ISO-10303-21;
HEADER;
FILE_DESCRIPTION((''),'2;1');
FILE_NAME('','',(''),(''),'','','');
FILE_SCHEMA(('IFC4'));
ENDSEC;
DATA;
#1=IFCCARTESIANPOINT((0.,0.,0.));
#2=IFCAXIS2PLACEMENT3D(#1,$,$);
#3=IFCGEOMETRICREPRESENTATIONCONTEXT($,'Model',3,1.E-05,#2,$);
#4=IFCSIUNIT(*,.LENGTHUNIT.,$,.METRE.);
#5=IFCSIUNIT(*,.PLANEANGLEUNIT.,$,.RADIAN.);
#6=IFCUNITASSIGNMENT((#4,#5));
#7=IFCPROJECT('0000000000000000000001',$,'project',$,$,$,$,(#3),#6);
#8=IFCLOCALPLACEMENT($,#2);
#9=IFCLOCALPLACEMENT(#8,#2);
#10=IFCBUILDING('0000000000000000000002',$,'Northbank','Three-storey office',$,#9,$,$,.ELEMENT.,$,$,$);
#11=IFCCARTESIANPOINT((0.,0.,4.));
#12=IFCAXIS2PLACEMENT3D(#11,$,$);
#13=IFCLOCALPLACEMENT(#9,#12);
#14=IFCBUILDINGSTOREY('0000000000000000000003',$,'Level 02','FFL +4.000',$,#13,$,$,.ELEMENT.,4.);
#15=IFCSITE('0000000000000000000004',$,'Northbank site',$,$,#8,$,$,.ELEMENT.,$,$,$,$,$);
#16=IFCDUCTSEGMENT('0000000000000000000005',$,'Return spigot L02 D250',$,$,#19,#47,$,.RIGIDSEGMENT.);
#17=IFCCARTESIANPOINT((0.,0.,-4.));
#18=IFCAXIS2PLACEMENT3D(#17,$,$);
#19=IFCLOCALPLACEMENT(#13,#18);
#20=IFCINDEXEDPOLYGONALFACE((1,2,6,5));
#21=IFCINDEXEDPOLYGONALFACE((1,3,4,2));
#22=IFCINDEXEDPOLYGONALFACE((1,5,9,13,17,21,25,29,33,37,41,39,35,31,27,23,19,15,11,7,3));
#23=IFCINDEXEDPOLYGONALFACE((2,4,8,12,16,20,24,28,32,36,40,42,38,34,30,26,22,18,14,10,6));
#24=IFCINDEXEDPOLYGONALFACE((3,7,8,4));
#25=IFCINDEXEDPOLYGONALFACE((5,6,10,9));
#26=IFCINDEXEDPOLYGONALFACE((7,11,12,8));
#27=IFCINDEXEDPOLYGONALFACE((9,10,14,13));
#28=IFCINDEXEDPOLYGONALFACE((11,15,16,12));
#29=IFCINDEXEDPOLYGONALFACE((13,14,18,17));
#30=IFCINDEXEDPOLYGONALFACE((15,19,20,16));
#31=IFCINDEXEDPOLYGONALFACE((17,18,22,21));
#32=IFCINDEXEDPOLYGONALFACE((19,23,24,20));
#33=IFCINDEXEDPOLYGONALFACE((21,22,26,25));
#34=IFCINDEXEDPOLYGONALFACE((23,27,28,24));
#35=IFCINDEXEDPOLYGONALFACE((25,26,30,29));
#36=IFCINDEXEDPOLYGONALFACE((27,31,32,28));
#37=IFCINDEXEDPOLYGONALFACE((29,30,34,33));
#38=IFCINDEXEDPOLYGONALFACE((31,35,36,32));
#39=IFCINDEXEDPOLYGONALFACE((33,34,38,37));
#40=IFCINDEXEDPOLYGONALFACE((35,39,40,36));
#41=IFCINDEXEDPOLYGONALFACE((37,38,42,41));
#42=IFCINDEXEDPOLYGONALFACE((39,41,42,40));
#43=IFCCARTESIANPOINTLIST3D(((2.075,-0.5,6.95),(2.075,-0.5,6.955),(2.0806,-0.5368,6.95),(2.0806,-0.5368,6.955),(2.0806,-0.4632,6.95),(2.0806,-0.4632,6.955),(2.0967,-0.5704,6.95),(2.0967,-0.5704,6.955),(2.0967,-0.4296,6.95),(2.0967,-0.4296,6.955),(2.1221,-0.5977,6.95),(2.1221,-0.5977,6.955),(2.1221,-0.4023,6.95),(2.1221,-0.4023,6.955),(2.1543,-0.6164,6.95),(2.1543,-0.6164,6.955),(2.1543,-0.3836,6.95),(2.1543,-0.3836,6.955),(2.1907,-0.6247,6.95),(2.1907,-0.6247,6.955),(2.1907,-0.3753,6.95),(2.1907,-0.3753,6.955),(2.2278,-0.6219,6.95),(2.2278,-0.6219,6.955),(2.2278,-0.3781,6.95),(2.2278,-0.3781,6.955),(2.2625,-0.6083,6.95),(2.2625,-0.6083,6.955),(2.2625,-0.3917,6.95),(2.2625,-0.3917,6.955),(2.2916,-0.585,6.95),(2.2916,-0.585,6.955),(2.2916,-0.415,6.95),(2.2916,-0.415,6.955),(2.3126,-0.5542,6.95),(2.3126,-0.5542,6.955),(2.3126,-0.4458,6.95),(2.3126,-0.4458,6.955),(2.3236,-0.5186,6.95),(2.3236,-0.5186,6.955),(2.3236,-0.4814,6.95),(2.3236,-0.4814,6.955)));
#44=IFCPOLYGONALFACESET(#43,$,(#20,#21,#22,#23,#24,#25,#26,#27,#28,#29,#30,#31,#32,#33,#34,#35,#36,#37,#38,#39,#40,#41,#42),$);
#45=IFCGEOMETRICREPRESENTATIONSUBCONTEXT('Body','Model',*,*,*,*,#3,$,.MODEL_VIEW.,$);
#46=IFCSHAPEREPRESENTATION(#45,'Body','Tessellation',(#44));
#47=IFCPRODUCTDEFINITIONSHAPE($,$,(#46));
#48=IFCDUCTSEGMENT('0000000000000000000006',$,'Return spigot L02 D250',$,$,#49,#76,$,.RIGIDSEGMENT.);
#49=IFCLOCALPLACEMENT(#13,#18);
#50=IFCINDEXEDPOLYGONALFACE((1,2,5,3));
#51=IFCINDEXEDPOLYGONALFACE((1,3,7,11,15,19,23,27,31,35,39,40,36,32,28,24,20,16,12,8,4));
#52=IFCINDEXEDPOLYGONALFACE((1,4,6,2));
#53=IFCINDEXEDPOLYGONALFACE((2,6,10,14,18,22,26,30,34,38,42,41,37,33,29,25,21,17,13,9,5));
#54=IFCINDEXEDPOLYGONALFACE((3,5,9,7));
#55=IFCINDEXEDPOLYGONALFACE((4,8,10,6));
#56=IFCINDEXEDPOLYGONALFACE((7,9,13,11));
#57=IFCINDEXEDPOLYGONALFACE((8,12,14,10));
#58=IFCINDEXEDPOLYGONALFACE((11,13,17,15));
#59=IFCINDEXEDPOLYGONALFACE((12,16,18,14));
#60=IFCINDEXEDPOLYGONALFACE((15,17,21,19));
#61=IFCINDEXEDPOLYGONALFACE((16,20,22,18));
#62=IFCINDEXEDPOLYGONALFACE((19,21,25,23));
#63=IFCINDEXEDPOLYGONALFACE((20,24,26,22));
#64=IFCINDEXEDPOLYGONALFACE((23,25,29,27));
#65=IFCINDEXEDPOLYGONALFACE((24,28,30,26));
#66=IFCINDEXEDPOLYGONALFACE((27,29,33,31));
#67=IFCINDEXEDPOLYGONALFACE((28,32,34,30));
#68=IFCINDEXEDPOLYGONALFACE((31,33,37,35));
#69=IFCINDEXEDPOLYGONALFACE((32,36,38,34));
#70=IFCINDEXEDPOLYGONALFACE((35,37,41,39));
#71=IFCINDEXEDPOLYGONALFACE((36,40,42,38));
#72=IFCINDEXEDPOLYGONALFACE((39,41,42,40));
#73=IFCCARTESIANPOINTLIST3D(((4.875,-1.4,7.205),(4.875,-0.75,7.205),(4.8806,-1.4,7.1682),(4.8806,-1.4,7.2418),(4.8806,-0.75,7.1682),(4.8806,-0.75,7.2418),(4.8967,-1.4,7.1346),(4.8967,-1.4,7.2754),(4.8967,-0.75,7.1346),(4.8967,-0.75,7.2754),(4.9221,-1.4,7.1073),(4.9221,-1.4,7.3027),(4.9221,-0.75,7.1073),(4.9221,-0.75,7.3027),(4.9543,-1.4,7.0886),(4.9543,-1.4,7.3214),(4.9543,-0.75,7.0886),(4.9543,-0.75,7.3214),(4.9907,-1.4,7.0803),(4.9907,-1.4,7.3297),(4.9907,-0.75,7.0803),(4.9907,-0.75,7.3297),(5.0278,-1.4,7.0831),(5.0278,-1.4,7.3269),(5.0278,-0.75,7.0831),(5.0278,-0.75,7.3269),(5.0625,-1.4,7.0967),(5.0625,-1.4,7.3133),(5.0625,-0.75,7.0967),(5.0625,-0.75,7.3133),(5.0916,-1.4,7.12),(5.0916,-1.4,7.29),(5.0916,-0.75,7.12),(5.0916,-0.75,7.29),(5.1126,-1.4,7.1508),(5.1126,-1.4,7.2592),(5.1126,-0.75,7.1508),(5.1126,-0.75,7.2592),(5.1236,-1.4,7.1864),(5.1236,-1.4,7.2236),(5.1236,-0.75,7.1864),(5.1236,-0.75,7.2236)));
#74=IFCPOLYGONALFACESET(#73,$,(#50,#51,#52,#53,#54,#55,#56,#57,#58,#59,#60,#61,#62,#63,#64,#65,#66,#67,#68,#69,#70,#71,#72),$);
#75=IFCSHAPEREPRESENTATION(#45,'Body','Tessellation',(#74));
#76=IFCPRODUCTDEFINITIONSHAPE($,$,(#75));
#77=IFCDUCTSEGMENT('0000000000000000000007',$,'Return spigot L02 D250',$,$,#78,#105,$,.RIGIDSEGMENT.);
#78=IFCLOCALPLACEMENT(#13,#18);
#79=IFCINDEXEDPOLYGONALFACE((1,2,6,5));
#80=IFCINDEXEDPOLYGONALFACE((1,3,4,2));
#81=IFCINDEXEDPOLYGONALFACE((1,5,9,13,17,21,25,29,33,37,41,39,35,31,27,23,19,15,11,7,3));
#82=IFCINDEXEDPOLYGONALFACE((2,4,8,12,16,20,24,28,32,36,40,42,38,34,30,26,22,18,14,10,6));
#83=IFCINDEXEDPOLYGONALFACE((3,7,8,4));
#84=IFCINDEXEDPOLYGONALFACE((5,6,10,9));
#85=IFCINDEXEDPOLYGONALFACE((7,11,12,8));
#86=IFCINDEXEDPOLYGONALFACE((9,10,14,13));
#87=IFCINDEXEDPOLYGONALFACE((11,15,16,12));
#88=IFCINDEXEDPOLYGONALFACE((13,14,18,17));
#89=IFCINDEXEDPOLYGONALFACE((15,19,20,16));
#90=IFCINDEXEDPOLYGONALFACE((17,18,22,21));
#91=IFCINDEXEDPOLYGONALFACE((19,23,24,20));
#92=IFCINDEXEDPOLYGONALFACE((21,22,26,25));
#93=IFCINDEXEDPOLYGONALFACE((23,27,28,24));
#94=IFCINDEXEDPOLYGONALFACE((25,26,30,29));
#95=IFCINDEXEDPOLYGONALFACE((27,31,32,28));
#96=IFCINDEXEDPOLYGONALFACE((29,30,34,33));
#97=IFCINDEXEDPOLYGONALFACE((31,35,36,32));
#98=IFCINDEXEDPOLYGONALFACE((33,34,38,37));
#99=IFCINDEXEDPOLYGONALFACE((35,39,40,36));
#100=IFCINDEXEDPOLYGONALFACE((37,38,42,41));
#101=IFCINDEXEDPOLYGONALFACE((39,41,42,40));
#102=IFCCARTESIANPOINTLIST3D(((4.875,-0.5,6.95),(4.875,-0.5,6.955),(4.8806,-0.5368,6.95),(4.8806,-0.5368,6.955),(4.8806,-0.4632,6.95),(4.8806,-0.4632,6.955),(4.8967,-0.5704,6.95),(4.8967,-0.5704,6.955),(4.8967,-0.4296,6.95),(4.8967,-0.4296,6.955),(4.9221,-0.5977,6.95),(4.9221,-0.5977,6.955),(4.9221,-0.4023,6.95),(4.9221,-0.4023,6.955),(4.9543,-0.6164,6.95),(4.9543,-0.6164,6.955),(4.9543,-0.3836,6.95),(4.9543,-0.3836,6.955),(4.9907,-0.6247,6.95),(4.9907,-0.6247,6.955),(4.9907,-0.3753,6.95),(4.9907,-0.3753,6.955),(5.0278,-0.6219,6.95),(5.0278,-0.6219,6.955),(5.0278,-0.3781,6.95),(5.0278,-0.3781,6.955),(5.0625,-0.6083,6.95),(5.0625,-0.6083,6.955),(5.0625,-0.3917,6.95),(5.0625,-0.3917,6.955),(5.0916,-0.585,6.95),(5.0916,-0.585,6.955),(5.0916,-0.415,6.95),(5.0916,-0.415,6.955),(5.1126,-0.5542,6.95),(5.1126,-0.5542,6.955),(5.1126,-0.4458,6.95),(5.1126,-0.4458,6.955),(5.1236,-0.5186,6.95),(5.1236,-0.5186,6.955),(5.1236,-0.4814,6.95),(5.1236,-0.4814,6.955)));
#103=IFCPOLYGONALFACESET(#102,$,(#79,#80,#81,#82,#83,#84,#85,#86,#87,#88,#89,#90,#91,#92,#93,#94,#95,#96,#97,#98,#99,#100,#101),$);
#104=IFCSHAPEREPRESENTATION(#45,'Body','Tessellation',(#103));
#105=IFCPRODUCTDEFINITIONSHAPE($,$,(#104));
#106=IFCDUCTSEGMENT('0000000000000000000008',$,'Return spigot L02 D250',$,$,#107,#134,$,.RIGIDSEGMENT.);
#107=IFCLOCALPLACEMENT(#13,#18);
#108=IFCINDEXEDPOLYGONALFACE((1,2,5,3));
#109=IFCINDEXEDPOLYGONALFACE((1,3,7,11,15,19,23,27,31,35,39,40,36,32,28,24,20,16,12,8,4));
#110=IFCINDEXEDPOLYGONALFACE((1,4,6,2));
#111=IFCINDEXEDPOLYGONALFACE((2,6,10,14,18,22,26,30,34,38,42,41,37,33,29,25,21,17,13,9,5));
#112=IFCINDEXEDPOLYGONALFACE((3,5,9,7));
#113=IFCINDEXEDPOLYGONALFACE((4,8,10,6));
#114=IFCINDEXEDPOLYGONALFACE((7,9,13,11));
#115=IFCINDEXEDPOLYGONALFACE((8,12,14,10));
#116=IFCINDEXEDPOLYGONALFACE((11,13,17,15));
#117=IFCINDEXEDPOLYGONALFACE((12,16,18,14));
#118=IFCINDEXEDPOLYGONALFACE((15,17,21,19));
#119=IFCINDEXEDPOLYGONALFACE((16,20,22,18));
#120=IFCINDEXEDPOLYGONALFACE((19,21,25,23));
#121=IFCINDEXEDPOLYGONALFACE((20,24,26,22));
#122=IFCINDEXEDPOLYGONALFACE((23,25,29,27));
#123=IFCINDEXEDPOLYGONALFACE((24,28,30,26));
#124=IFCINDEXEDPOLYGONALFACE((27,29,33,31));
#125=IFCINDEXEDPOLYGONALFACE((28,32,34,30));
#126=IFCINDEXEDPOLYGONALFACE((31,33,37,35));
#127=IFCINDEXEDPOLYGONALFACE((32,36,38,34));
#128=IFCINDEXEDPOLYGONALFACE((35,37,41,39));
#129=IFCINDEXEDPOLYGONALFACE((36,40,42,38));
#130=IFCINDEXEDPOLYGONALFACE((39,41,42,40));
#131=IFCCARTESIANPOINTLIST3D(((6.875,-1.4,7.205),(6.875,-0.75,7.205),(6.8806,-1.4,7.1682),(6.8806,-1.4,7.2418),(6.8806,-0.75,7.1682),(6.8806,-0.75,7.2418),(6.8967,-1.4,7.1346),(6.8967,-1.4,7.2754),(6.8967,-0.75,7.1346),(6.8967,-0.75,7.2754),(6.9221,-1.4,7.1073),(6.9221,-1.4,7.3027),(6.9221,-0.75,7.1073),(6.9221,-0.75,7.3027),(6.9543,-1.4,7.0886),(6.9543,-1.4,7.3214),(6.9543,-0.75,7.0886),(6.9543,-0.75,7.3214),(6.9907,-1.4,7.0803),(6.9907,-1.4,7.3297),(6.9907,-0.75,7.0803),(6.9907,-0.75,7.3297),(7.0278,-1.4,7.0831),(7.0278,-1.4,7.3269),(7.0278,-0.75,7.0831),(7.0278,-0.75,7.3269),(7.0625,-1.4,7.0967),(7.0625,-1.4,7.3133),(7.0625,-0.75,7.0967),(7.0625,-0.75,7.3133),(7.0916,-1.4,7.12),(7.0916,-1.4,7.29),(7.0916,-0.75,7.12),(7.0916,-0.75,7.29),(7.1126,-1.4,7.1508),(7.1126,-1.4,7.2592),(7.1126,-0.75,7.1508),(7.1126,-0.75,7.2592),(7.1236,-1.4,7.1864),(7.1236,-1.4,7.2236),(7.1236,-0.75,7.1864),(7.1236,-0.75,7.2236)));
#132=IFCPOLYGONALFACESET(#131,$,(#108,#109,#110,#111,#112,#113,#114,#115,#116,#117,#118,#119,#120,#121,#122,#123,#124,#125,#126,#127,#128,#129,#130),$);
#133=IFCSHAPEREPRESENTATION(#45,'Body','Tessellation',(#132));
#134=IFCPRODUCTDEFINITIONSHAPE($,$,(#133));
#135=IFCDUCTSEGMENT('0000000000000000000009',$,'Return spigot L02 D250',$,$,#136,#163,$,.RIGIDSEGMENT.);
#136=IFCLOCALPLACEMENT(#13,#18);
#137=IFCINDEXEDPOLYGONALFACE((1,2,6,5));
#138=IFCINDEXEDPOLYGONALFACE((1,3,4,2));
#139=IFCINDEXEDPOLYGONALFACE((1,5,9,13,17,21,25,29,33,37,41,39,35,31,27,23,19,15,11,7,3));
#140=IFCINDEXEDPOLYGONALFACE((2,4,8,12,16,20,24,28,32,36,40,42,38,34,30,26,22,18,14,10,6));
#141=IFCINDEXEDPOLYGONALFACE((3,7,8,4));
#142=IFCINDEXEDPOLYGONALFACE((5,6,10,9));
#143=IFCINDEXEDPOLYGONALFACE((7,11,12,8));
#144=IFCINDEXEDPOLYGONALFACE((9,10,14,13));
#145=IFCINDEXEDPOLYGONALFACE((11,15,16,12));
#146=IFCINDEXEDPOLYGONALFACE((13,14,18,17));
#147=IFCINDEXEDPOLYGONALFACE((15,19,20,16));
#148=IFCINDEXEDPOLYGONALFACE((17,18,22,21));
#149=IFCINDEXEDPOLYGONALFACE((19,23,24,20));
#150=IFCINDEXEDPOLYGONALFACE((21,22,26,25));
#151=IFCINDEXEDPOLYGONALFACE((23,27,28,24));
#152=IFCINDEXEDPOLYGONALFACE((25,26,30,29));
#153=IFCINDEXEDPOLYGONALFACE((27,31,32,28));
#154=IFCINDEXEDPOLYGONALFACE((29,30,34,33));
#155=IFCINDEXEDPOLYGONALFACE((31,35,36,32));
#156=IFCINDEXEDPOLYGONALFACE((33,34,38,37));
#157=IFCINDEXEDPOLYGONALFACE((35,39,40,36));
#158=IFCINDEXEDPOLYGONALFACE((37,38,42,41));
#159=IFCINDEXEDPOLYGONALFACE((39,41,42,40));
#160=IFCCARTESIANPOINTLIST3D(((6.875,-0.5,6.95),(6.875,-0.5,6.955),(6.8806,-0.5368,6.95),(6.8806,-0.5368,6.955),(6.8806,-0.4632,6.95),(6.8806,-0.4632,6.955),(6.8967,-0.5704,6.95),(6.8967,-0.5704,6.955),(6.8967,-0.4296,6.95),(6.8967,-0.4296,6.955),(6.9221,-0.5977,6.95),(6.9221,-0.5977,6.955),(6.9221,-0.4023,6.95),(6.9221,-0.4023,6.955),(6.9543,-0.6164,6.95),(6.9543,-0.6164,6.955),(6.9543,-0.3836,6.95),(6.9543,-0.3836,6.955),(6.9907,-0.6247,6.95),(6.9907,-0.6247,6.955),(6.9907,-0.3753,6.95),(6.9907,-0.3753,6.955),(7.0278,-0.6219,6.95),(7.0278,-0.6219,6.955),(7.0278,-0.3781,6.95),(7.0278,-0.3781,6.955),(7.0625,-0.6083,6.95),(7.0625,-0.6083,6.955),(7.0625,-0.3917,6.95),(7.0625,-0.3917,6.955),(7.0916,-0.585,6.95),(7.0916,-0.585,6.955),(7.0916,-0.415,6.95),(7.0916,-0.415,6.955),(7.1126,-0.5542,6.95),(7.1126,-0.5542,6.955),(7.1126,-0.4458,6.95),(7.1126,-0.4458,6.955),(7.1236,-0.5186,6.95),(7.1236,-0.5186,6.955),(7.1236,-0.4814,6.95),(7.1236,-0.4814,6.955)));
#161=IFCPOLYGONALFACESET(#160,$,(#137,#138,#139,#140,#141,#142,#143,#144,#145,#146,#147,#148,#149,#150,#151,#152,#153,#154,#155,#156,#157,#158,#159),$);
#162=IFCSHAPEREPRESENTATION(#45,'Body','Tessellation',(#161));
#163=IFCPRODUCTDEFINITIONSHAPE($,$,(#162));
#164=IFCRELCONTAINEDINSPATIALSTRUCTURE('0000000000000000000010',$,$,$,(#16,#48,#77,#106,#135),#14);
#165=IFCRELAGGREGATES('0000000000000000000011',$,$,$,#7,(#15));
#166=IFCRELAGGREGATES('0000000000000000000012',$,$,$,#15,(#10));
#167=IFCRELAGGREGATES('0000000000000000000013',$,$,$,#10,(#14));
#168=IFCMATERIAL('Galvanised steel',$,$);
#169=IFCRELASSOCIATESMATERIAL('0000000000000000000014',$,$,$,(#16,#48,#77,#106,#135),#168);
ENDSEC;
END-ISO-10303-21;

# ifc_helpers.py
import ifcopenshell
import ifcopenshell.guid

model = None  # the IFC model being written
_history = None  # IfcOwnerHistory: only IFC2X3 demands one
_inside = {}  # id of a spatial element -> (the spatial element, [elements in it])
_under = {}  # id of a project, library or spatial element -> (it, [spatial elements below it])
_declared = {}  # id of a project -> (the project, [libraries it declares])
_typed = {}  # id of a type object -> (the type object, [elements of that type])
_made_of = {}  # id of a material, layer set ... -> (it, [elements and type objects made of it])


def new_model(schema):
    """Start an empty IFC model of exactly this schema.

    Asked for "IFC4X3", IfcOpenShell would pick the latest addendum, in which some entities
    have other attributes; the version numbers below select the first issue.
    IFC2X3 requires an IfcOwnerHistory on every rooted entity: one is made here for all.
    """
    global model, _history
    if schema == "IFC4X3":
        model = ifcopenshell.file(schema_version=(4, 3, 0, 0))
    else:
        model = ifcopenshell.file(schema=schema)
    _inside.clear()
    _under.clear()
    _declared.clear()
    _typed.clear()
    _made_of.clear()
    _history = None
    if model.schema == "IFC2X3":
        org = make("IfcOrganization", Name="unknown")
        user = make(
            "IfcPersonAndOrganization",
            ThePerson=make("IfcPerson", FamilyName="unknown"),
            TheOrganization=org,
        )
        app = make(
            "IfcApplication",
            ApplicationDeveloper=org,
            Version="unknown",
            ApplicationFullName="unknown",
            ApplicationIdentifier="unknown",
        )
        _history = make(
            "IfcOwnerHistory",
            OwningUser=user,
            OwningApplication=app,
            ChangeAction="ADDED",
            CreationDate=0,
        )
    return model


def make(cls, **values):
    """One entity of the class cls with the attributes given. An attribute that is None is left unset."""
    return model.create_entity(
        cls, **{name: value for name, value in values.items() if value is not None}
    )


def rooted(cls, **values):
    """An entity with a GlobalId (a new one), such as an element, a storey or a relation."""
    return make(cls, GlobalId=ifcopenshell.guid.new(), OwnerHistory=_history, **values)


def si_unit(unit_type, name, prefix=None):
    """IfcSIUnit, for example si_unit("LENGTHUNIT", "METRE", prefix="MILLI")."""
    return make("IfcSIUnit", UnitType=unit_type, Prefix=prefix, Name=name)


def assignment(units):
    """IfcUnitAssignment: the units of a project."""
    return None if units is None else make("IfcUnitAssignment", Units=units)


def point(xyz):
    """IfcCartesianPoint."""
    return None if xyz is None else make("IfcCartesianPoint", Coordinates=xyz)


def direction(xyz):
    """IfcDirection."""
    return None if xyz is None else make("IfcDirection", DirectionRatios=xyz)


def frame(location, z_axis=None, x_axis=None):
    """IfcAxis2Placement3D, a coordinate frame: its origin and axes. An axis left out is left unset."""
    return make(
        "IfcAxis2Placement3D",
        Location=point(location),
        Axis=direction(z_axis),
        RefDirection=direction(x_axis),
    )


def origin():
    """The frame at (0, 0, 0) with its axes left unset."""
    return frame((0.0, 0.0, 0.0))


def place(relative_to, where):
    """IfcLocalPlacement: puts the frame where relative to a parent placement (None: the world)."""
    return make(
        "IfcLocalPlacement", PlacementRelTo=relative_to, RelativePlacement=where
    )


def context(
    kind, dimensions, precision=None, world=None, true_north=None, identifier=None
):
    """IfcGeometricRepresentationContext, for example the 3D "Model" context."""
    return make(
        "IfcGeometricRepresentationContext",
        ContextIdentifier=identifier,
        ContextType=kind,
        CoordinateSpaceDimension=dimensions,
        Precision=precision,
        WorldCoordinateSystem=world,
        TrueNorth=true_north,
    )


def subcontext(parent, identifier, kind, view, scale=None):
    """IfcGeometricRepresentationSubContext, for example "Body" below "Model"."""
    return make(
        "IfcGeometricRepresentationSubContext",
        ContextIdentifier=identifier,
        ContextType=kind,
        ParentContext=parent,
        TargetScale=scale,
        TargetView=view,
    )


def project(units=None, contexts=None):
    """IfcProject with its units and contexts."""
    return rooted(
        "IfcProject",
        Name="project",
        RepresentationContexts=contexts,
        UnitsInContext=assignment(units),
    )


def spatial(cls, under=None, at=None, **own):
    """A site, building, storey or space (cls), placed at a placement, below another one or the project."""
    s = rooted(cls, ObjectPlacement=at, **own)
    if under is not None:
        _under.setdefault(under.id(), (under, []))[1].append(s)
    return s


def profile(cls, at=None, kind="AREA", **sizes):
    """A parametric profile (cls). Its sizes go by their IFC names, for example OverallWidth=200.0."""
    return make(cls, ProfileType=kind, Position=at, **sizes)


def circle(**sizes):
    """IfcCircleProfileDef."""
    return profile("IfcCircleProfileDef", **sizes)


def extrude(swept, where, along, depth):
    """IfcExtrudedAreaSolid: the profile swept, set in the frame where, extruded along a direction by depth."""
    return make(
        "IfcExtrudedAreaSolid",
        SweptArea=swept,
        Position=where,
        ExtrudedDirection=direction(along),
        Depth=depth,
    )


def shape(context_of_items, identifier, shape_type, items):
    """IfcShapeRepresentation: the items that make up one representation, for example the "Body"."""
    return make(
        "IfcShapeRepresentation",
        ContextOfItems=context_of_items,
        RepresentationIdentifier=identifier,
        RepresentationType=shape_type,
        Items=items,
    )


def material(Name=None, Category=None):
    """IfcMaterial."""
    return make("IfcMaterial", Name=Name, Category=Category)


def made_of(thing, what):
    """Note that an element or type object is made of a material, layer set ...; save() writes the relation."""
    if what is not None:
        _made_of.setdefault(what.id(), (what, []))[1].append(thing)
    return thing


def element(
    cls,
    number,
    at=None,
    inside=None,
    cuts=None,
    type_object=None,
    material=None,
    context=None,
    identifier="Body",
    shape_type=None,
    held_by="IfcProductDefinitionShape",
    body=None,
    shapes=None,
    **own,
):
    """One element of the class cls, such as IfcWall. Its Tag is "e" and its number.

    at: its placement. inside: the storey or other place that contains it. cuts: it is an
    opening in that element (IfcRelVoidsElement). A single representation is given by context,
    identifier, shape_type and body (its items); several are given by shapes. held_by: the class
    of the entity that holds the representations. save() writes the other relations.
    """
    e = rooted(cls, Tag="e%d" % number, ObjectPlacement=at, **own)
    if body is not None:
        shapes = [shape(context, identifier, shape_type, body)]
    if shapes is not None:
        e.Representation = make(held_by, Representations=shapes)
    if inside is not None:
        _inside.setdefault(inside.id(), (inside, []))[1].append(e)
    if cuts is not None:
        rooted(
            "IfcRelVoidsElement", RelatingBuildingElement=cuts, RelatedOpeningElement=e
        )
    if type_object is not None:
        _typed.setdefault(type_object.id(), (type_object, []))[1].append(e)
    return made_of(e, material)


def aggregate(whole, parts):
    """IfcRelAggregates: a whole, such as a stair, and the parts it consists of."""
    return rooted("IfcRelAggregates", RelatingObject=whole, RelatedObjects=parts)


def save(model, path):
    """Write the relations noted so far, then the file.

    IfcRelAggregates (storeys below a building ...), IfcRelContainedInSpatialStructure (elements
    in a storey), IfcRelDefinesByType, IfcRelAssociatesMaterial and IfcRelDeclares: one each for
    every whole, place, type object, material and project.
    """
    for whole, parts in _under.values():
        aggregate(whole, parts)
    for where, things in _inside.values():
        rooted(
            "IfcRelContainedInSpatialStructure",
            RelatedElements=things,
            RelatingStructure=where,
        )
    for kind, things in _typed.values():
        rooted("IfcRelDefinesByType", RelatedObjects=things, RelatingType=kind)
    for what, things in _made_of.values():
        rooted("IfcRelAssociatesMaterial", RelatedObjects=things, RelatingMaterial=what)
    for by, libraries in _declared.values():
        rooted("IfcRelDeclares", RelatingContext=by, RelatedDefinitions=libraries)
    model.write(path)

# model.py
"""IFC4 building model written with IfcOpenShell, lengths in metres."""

from ifc_helpers import new_model, si_unit, frame, origin, place, context, subcontext, project, spatial, circle, extrude, material, element, save


model = new_model("IFC4")

# Units and contexts
model_context = context("Model", 3, precision=1e-05, world=origin())
body_context = subcontext(model_context, "Body", "Model", "MODEL_VIEW")
ifc_project = project(units=[si_unit("LENGTHUNIT", "METRE"), si_unit("PLANEANGLEUNIT", "RADIAN")], contexts=[model_context])

# Site, building, storey
site_placement = place(None, origin())
site = spatial("IfcSite", under=ifc_project, at=site_placement, Name="Northbank site", CompositionType="ELEMENT")
building_placement = place(site_placement, origin())
building = spatial("IfcBuilding", under=site, at=building_placement, Name="Northbank", Description="Three-storey office", CompositionType="ELEMENT")
storey_placement = place(building_placement, frame((0.0, 0.0, 4.0)))
storey = spatial("IfcBuildingStorey", under=building, at=storey_placement, Name="Level 02", Description="FFL +4.000", CompositionType="ELEMENT", Elevation=4.0)

# Shared definitions
ifc_material_1 = material(Name="Galvanised steel")

# Duct segment
duct_segment_1_placement = place(storey_placement, frame((0.0, 0.0, -4.0)))
element("IfcDuctSegment", 1, at=duct_segment_1_placement, inside=storey, material=ifc_material_1, Name="Return spigot L02 D250", PredefinedType="RIGIDSEGMENT", context=body_context, shape_type="SweptSolid", body=[
    extrude(circle(Radius=0.125), frame((2.2, -0.5, 6.955), z_axis=(0.0, 0.0, -1.0), x_axis=(-1.0, 0.0, 0.0)), (0.0, 0.0, 1.0), 0.005),
])

# Duct segments
duct_segment_2_placement = place(storey_placement, frame((0.0, 0.0, -4.0)))
element("IfcDuctSegment", 2, at=duct_segment_2_placement, inside=storey, material=ifc_material_1, Name="Return spigot L02 D250", PredefinedType="RIGIDSEGMENT", context=body_context, shape_type="SweptSolid", body=[
    extrude(circle(Radius=0.125), frame((5.0, -1.4, 7.205), z_axis=(0.0, 1.0, 0.0), x_axis=(-1.0, 0.0, 0.0)), (0.0, 0.0, 1.0), 0.65),
])
duct_segment_3_placement = place(storey_placement, frame((0.0, 0.0, -4.0)))
element("IfcDuctSegment", 3, at=duct_segment_3_placement, inside=storey, material=ifc_material_1, Name="Return spigot L02 D250", PredefinedType="RIGIDSEGMENT", context=body_context, shape_type="SweptSolid", body=[
    extrude(circle(Radius=0.125), frame((5.0, -0.5, 6.955), z_axis=(0.0, 0.0, -1.0), x_axis=(-1.0, 0.0, 0.0)), (0.0, 0.0, 1.0), 0.005),
])

# Duct segments
duct_segment_4_placement = place(storey_placement, frame((0.0, 0.0, -4.0)))
element("IfcDuctSegment", 4, at=duct_segment_4_placement, inside=storey, material=ifc_material_1, Name="Return spigot L02 D250", PredefinedType="RIGIDSEGMENT", context=body_context, shape_type="SweptSolid", body=[
    extrude(circle(Radius=0.125), frame((7.0, -1.4, 7.205), z_axis=(0.0, 1.0, 0.0), x_axis=(-1.0, 0.0, 0.0)), (0.0, 0.0, 1.0), 0.65),
])
duct_segment_5_placement = place(storey_placement, frame((0.0, 0.0, -4.0)))
element("IfcDuctSegment", 5, at=duct_segment_5_placement, inside=storey, material=ifc_material_1, Name="Return spigot L02 D250", PredefinedType="RIGIDSEGMENT", context=body_context, shape_type="SweptSolid", body=[
    extrude(circle(Radius=0.125), frame((7.0, -0.5, 6.955), z_axis=(0.0, 0.0, -1.0), x_axis=(-1.0, 0.0, 0.0)), (0.0, 0.0, 1.0), 0.005),
])

save(model, "model.ifc")
